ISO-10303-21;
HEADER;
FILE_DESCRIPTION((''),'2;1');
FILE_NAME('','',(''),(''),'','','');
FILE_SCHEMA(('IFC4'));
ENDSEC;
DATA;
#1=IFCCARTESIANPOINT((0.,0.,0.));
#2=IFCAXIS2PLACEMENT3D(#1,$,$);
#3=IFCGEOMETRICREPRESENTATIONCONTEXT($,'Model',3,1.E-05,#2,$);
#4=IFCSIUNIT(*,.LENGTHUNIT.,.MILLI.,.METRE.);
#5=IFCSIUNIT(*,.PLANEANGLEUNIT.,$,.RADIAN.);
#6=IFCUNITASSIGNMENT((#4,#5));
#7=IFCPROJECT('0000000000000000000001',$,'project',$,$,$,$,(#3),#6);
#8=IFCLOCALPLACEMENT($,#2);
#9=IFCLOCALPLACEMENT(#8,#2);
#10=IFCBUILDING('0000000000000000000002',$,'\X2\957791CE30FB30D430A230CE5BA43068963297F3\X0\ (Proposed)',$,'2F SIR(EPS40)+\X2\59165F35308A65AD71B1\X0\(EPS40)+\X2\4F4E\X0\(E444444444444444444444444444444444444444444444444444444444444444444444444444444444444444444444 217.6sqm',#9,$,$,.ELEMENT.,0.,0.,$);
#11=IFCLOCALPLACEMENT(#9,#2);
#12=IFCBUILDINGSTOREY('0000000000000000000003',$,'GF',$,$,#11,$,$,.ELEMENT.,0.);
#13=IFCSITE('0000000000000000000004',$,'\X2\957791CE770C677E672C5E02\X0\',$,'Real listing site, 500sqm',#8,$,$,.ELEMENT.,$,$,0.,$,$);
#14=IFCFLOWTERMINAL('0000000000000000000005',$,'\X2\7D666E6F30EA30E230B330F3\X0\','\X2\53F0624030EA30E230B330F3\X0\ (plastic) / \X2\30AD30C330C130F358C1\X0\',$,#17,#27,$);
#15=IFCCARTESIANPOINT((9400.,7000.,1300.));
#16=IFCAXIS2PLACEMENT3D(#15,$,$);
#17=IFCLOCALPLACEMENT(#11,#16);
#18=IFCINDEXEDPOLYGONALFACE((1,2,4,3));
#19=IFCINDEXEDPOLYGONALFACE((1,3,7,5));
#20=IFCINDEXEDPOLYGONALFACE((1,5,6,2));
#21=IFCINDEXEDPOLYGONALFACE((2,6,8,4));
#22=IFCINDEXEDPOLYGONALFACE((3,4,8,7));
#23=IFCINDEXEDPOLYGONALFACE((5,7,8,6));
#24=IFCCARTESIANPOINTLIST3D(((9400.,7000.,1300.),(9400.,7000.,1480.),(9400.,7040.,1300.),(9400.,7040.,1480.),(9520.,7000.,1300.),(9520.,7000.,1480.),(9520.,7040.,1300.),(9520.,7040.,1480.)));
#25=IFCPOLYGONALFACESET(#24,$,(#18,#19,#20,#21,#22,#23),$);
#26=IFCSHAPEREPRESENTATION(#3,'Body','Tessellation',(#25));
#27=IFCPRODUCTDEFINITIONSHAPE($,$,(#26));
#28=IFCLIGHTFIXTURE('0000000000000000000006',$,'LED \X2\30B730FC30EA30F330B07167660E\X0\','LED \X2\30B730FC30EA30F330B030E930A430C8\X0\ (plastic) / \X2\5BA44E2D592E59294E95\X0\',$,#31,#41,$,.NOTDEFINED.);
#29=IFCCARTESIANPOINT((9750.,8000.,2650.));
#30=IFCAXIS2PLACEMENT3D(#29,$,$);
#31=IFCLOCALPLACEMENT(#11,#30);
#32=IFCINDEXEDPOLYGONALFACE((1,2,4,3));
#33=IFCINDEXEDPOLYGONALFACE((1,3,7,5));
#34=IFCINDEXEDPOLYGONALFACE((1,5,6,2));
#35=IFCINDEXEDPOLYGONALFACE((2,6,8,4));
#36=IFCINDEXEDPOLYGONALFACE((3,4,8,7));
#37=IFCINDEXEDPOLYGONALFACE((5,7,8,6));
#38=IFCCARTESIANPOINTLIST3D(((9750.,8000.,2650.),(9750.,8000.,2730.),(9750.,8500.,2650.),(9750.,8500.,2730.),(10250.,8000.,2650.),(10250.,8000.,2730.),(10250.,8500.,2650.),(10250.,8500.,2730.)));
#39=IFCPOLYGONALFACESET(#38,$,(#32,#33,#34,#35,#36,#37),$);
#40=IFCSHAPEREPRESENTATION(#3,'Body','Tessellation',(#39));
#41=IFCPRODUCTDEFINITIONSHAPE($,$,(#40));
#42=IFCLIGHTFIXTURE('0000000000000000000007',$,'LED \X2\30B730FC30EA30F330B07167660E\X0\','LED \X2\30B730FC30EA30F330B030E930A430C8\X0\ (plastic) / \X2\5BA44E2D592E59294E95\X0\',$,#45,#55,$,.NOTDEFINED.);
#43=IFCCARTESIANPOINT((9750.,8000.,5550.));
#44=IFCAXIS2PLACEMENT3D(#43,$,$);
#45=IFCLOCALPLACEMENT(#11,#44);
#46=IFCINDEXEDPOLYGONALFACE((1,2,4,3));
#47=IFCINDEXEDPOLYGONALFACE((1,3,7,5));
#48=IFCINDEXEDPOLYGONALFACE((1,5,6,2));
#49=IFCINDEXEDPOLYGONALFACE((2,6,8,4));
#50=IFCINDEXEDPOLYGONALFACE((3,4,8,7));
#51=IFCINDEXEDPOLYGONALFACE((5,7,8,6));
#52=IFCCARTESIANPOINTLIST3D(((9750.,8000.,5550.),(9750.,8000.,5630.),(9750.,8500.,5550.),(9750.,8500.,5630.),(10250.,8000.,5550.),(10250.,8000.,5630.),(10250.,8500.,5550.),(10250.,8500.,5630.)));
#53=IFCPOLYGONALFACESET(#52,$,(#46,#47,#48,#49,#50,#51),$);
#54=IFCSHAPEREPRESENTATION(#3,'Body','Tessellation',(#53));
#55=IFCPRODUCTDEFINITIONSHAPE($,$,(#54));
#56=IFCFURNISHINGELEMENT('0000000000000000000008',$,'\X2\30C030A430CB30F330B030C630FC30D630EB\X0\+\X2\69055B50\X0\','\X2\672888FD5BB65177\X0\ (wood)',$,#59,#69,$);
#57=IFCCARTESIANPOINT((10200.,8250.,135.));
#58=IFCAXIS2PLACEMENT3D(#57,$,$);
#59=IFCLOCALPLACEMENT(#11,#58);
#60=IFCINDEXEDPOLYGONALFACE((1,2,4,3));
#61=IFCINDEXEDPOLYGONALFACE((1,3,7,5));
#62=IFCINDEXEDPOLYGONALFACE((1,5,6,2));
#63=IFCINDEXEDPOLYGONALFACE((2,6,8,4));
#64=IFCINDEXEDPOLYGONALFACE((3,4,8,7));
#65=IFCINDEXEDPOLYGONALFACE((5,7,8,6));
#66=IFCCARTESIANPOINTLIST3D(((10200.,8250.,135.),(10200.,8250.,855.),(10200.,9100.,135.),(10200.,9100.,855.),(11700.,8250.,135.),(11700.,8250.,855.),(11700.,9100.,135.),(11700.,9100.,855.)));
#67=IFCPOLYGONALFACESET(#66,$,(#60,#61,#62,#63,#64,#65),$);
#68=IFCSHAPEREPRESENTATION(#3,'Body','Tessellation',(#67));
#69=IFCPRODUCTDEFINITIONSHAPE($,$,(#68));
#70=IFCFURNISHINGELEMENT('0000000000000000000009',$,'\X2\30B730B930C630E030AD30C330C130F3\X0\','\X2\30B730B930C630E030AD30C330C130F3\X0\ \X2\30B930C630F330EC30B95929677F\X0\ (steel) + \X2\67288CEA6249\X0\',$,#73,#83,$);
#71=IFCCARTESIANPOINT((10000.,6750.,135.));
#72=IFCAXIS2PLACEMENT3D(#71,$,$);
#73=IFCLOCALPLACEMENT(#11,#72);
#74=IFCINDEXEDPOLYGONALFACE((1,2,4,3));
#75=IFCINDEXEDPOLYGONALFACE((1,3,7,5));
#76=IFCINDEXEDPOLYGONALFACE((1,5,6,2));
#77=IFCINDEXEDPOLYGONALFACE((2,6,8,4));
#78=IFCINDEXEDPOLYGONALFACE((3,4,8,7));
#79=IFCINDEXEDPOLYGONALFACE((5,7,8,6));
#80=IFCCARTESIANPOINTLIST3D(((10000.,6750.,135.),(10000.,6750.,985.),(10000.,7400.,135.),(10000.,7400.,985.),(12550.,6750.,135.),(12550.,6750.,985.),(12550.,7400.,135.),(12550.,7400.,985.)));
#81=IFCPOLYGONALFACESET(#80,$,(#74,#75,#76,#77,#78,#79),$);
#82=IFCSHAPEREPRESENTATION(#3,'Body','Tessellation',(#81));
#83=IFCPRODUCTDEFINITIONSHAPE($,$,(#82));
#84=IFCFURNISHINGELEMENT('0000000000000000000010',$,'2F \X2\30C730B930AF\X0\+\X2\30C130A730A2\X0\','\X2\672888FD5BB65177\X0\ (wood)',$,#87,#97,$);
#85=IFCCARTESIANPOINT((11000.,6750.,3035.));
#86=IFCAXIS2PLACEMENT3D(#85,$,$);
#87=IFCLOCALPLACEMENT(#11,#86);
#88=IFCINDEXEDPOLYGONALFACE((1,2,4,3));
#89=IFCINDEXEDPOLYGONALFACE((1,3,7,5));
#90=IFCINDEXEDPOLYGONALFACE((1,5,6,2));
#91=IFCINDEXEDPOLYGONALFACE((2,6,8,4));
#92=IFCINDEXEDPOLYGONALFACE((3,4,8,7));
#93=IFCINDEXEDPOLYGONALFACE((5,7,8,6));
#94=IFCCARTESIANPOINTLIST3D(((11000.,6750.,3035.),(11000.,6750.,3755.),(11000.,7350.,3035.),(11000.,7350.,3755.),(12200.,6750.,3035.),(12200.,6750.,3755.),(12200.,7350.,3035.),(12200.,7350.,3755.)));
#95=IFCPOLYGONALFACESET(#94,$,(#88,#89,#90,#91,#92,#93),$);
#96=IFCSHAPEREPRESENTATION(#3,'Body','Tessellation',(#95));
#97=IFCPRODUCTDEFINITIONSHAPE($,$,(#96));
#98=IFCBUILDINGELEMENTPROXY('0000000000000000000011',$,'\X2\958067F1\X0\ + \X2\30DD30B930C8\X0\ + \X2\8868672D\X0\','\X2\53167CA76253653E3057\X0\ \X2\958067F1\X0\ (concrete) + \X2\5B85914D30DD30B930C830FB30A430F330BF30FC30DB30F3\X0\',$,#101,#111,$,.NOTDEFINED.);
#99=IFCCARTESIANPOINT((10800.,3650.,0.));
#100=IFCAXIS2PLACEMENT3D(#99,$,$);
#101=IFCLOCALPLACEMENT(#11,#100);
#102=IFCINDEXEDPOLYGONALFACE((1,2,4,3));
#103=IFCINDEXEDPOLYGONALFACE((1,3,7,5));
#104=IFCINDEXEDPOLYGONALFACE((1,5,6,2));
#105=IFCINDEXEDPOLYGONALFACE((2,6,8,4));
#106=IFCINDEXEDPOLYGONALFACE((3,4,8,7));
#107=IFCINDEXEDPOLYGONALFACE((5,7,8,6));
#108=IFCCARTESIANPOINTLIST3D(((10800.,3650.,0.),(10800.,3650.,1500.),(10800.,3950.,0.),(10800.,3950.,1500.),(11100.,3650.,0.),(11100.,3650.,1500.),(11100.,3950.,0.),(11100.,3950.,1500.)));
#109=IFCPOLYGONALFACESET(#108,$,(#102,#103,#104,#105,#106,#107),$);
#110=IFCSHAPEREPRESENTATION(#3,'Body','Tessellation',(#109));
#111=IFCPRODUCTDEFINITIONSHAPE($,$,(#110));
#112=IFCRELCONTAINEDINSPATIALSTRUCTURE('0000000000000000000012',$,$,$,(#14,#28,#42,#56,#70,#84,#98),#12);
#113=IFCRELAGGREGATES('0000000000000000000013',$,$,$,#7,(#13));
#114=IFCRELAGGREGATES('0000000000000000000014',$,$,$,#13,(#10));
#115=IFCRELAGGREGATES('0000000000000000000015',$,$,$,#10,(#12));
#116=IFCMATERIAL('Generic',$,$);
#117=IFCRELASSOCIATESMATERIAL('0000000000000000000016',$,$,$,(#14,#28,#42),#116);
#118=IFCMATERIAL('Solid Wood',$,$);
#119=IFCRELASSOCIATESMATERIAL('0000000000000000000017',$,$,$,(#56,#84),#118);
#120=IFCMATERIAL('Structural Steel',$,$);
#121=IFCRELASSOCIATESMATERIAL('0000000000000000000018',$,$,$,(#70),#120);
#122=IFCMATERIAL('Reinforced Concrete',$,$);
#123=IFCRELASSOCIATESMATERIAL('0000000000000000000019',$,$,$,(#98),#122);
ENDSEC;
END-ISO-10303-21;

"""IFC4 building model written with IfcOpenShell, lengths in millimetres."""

from ifc_helpers import new_model, si_unit, frame, frame_2d, origin, place, context, project, spatial, rectangle, extrude, material, element, save


model = new_model("IFC4")

# Units and contexts
model_context = context("Model", 3, precision=1e-05, world=origin())
ifc_project = project(units=[si_unit("LENGTHUNIT", "METRE", prefix="MILLI"), si_unit("PLANEANGLEUNIT", "RADIAN")], contexts=[model_context])

# Site, building, storey
site_placement = place(None, origin())
site = spatial("IfcSite", under=ifc_project, at=site_placement, Name="長野県松本市", ObjectType="Real listing site, 500sqm", CompositionType="ELEMENT", RefElevation=0.0)
building_placement = place(site_placement, origin())
building = spatial("IfcBuilding", under=site, at=building_placement, Name="長野・ピアノ室と防音 (Proposed)", ObjectType="2F SIR(EPS40)+外張り断熱(EPS40)+低(E444444444444444444444444444444444444444444444444444444444444444444444444444444444444444444444 217.6sqm", CompositionType="ELEMENT", ElevationOfRefHeight=0.0, ElevationOfTerrain=0.0)
storey_placement = place(building_placement, origin())
storey = spatial("IfcBuildingStorey", under=building, at=storey_placement, Name="GF", CompositionType="ELEMENT", Elevation=0.0)

# Shared definitions
ifc_material_1 = material(Name="Solid Wood")

# Shared definitions
ifc_material_2 = material(Name="Structural Steel")

# Shared definitions
ifc_material_3 = material(Name="Reinforced Concrete")

# Flow terminal
ifc_material_4 = material(Name="Generic")
flow_terminal_1_placement = place(storey_placement, frame((9400.0, 7000.0, 1300.0)))
element("IfcFlowTerminal", 1, at=flow_terminal_1_placement, inside=storey, material=ifc_material_4, Name="給湯リモコン", Description="台所リモコン (plastic) / キッチン壁", context=model_context, shape_type="SweptSolid", body=[
    extrude(rectangle(XDim=120.0, YDim=40.0, at=frame_2d((60.0, 20.0))), frame((9400.0, 7000.0, 1300.0)), (0.0, 0.0, 1.0), 180.0),
])

# Light fixtures
light_fixture_1_placement = place(storey_placement, frame((9750.0, 8000.0, 2650.0)))
element("IfcLightFixture", 2, at=light_fixture_1_placement, inside=storey, material=ifc_material_4, Name="LED シーリング照明", Description="LED シーリングライト (plastic) / 室中央天井", PredefinedType="NOTDEFINED", context=model_context, shape_type="SweptSolid", body=[
    extrude(rectangle(XDim=500.0, YDim=500.0, at=frame_2d((250.0, 250.0))), frame((9750.0, 8000.0, 2650.0)), (0.0, 0.0, 1.0), 80.0),
])
light_fixture_2_placement = place(storey_placement, frame((9750.0, 8000.0, 5550.0)))
element("IfcLightFixture", 3, at=light_fixture_2_placement, inside=storey, material=ifc_material_4, Name="LED シーリング照明", Description="LED シーリングライト (plastic) / 室中央天井", PredefinedType="NOTDEFINED", context=model_context, shape_type="SweptSolid", body=[
    extrude(rectangle(XDim=500.0, YDim=500.0, at=frame_2d((250.0, 250.0))), frame((9750.0, 8000.0, 5550.0)), (0.0, 0.0, 1.0), 80.0),
])

# Furnishing elements
furnishing_1_placement = place(storey_placement, frame((10200.0, 8250.0, 135.0)))
element("IfcFurnishingElement", 4, at=furnishing_1_placement, inside=storey, material=ifc_material_1, Name="ダイニングテーブル+椅子", Description="木製家具 (wood)", context=model_context, shape_type="SweptSolid", body=[
    extrude(rectangle(XDim=1500.0, YDim=850.0, at=frame_2d((750.0, 425.0))), frame((10200.0, 8250.0, 135.0)), (0.0, 0.0, 1.0), 720.0),
])
furnishing_2_placement = place(storey_placement, frame((10000.0, 6750.0, 135.0)))
element("IfcFurnishingElement", 5, at=furnishing_2_placement, inside=storey, material=ifc_material_2, Name="システムキッチン", Description="システムキッチン ステンレス天板 (steel) + 木質扉", context=model_context, shape_type="SweptSolid", body=[
    extrude(rectangle(XDim=2550.0, YDim=650.0, at=frame_2d((1275.0, 325.0))), frame((10000.0, 6750.0, 135.0)), (0.0, 0.0, 1.0), 850.0),
])
furnishing_3_placement = place(storey_placement, frame((11000.0, 6750.0, 3035.0)))
element("IfcFurnishingElement", 6, at=furnishing_3_placement, inside=storey, material=ifc_material_1, Name="2F デスク+チェア", Description="木製家具 (wood)", context=model_context, shape_type="SweptSolid", body=[
    extrude(rectangle(XDim=1200.0, YDim=600.0, at=frame_2d((600.0, 300.0))), frame((11000.0, 6750.0, 3035.0)), (0.0, 0.0, 1.0), 720.0),
])

# Building element proxy
proxy_placement = place(storey_placement, frame((10800.0, 3650.0, 0.0)))
element("IfcBuildingElementProxy", 7, at=proxy_placement, inside=storey, material=ifc_material_3, Name="門柱 + ポスト + 表札", Description="化粧打放し 門柱 (concrete) + 宅配ポスト・インターホン", PredefinedType="NOTDEFINED", context=model_context, shape_type="SweptSolid", body=[
    extrude(rectangle(XDim=300.0, YDim=300.0, at=frame_2d((150.0, 150.0))), frame((10800.0, 3650.0, 0.0)), (0.0, 0.0, 1.0), 1500.0),
])

save(model, "model.ifc")
